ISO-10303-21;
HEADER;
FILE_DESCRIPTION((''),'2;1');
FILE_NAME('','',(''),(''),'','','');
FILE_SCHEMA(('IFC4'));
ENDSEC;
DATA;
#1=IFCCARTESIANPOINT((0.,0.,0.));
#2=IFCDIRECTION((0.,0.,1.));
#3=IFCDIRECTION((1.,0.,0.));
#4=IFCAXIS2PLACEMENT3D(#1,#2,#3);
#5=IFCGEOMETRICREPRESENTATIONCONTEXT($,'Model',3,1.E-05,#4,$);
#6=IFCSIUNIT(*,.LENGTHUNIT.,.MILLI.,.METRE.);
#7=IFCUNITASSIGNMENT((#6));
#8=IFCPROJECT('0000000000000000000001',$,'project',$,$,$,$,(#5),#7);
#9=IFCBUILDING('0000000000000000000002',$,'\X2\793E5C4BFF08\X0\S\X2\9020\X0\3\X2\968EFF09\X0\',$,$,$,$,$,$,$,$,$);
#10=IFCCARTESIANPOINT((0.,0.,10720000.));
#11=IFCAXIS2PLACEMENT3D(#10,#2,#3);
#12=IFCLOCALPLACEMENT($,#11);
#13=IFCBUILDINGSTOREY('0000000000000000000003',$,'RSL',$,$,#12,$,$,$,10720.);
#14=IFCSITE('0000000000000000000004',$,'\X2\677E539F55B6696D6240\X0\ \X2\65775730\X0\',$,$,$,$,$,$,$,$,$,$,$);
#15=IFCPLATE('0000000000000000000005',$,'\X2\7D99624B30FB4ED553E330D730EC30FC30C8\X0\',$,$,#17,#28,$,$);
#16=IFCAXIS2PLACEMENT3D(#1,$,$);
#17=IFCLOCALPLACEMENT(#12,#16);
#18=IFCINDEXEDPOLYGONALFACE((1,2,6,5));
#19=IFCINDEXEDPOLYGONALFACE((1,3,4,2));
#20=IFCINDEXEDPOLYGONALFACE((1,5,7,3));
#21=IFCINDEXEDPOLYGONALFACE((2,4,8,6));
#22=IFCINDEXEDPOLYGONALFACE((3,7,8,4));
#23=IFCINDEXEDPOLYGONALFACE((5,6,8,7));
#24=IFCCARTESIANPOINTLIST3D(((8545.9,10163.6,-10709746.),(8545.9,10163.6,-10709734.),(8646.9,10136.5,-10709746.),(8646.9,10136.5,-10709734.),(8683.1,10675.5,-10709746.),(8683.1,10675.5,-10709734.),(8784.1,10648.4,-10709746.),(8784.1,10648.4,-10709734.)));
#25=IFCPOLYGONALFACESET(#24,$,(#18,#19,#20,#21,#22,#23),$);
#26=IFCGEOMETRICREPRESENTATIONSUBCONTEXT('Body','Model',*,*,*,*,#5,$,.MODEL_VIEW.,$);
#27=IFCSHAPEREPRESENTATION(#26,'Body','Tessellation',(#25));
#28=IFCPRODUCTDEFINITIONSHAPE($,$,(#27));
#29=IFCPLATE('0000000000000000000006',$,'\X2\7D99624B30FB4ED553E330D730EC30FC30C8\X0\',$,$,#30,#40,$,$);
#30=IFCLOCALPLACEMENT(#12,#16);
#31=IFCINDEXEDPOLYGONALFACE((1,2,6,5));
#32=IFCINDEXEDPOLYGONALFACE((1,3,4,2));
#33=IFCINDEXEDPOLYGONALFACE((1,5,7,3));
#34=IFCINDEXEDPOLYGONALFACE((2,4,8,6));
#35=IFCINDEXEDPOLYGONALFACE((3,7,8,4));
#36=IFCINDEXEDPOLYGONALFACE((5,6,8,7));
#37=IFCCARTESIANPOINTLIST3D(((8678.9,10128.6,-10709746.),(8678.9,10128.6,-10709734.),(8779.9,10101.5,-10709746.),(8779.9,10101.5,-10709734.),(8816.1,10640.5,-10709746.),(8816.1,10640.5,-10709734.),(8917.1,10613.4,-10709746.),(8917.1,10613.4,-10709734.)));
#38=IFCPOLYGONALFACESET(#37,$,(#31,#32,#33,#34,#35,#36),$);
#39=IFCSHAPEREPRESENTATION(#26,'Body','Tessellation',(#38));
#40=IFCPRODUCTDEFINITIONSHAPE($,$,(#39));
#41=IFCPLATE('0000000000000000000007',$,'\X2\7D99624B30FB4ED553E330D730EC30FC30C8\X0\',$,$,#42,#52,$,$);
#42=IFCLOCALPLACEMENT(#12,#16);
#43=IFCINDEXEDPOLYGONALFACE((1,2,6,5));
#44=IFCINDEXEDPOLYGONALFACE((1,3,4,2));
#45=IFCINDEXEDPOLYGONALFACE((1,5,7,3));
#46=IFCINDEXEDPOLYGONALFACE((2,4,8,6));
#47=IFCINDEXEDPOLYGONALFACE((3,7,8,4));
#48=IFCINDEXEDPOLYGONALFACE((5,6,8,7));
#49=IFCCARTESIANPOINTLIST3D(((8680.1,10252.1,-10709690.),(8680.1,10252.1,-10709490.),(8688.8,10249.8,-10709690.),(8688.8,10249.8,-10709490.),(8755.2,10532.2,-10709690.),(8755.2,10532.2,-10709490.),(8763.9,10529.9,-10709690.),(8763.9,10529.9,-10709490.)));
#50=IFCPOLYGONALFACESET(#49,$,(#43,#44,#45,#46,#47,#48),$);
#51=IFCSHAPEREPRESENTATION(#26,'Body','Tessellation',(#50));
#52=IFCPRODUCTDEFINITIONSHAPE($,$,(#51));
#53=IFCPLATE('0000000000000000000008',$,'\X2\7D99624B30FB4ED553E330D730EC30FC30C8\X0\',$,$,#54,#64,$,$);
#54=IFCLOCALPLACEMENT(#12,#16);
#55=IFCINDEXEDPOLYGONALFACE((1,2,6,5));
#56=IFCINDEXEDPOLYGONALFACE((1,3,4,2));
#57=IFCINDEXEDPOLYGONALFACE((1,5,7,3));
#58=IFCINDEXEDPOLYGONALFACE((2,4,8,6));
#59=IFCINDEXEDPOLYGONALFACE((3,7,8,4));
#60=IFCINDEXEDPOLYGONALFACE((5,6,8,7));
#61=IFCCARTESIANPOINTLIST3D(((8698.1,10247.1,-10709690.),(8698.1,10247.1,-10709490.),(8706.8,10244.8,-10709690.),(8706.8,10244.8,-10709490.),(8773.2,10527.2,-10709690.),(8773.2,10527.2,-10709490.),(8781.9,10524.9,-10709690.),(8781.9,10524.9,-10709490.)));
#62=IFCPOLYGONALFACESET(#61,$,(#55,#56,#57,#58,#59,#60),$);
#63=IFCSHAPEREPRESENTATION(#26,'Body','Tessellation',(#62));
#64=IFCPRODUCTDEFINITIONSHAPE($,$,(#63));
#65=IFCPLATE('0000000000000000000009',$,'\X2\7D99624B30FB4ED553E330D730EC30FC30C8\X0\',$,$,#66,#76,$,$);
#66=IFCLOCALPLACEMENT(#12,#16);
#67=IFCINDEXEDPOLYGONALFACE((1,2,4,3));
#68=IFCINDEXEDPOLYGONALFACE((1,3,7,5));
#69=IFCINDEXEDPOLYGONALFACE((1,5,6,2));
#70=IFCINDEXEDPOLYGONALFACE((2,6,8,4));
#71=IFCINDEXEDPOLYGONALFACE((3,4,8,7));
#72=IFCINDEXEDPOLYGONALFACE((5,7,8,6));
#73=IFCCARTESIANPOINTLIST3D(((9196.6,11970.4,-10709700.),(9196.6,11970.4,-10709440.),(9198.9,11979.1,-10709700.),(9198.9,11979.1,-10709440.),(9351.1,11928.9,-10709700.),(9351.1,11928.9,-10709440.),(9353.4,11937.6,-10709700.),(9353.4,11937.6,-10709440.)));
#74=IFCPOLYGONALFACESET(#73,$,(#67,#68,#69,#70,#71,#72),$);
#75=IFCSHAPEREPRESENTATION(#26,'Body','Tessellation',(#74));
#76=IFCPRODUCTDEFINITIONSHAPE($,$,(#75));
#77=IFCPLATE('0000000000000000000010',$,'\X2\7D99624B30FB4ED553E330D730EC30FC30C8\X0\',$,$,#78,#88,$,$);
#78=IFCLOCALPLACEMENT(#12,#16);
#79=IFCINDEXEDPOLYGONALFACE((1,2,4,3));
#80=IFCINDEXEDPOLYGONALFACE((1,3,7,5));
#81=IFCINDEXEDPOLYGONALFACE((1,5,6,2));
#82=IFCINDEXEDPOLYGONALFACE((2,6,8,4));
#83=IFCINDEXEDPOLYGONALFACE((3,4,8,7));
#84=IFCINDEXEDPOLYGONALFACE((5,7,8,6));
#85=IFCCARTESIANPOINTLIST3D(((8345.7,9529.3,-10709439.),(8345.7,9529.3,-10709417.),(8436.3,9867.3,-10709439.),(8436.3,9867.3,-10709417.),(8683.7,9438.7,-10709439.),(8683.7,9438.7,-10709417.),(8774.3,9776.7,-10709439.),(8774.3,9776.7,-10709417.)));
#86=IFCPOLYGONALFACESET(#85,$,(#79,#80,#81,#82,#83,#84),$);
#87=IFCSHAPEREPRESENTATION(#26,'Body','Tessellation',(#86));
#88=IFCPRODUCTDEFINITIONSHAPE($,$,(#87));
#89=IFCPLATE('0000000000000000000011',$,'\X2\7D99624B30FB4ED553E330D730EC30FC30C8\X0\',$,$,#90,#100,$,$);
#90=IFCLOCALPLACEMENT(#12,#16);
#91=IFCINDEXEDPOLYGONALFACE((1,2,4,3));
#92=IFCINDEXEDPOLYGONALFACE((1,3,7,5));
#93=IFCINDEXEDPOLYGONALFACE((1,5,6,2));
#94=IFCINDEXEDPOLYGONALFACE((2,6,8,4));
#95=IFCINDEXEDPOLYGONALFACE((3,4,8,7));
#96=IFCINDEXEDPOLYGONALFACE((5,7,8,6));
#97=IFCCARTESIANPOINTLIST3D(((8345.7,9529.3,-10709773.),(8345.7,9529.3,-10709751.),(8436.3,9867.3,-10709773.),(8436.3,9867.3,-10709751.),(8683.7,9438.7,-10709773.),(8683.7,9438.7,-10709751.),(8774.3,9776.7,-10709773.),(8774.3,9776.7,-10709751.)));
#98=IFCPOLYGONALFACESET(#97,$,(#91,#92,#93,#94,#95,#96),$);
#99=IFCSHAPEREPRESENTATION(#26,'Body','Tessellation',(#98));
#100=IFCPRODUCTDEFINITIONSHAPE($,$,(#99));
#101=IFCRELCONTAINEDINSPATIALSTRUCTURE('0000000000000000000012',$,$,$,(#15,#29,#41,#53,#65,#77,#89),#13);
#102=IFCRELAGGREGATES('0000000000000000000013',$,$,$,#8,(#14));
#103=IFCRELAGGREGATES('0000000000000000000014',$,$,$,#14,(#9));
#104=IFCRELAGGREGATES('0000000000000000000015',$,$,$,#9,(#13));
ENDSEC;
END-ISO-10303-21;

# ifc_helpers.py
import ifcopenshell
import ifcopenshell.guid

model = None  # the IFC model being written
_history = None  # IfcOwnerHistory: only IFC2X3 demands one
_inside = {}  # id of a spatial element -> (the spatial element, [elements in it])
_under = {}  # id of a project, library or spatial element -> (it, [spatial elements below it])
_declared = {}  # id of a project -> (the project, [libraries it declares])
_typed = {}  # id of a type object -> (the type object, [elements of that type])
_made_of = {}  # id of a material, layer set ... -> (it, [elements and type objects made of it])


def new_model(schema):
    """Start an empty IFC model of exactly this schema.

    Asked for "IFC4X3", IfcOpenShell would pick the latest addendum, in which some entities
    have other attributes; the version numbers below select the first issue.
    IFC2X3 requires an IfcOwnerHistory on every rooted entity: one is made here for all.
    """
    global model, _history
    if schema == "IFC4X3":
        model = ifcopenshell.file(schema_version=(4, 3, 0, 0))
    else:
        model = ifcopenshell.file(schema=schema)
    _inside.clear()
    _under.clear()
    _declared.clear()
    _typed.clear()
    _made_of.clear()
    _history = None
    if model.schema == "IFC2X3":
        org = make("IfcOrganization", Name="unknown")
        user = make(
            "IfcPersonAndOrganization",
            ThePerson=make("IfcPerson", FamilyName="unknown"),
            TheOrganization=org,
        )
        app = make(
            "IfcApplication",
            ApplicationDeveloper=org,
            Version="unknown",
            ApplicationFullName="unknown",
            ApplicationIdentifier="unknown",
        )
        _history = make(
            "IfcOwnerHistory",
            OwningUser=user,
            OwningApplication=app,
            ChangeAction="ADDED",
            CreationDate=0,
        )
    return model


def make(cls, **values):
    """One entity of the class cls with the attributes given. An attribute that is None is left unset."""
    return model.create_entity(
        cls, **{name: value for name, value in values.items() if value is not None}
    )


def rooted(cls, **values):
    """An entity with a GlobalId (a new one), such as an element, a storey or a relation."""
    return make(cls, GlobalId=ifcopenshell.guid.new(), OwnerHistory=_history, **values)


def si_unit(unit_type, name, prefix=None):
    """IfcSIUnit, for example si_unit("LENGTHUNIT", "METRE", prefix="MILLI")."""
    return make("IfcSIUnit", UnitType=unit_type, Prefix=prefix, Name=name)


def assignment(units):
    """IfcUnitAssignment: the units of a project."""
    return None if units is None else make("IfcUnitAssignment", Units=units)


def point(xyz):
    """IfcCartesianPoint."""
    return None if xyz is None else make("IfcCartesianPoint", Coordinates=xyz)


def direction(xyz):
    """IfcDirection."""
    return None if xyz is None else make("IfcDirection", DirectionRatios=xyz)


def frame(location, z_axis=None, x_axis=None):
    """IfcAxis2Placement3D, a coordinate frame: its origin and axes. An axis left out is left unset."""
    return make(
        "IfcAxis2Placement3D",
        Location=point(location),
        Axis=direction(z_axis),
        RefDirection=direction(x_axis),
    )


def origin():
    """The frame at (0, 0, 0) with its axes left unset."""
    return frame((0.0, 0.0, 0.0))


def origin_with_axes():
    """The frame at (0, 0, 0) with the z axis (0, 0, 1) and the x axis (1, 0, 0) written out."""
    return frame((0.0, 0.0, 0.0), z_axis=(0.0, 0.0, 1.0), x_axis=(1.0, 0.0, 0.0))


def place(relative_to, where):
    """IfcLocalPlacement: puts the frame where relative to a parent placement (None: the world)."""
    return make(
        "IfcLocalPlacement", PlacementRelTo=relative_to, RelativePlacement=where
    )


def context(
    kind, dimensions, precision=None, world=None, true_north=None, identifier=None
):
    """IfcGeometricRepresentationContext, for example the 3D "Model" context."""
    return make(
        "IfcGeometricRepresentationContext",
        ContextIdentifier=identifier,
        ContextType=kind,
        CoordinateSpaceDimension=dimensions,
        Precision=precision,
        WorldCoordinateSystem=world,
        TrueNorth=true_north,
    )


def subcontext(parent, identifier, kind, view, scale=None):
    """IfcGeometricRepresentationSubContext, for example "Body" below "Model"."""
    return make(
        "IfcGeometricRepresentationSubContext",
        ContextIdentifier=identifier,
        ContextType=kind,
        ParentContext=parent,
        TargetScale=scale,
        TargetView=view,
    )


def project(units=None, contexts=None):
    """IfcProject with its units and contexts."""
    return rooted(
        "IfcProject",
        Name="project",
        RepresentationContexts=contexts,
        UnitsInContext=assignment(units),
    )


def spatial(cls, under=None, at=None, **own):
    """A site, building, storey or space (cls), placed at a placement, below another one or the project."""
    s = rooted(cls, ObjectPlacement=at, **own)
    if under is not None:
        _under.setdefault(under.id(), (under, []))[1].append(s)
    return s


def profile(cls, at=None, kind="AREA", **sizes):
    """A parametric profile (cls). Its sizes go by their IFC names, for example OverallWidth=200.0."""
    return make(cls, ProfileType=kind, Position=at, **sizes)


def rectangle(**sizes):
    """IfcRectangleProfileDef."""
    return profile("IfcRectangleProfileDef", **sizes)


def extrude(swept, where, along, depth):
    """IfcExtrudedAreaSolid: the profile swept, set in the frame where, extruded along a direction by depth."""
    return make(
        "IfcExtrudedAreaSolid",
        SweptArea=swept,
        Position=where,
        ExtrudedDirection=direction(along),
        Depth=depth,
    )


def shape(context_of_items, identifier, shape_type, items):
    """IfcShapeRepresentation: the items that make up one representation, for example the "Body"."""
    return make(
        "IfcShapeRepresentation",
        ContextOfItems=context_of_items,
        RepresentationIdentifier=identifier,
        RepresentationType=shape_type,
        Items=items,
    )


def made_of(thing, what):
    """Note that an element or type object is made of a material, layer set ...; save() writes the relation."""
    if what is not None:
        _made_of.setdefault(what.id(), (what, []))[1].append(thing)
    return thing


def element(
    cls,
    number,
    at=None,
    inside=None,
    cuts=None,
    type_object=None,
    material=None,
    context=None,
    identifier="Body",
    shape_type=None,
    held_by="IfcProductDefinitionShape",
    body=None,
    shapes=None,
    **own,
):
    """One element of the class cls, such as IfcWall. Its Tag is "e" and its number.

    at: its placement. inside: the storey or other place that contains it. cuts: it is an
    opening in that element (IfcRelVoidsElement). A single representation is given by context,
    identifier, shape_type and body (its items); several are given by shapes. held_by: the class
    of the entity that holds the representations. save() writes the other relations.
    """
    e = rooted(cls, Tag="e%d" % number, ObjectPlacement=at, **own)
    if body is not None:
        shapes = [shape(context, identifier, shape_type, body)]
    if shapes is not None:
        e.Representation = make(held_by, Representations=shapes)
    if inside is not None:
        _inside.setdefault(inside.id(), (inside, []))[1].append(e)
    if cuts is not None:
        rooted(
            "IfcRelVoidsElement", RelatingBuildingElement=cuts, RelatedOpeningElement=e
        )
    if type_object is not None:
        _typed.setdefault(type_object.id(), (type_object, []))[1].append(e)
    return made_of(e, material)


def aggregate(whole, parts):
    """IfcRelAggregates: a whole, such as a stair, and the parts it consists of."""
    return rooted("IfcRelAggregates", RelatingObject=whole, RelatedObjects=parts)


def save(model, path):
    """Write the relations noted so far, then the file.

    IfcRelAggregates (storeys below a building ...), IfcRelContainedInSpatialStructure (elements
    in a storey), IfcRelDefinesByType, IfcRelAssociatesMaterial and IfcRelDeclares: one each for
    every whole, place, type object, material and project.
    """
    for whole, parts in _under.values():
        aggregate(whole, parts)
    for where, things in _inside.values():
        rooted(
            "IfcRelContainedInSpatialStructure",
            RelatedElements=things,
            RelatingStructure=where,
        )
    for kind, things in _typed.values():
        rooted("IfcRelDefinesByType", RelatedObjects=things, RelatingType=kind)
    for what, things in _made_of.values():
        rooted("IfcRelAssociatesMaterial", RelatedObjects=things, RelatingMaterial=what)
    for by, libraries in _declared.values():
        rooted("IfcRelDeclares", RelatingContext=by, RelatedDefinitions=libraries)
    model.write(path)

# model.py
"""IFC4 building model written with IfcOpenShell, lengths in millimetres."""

from ifc_helpers import new_model, si_unit, frame, origin, origin_with_axes, place, context, subcontext, project, spatial, rectangle, extrude, element, save


model = new_model("IFC4")

# Units and contexts
model_context = context("Model", 3, precision=1e-05, world=origin_with_axes())
body_context = subcontext(model_context, "Body", "Model", "MODEL_VIEW")
ifc_project = project(units=[si_unit("LENGTHUNIT", "METRE", prefix="MILLI")], contexts=[model_context])

# Site, building, storey
site = spatial("IfcSite", under=ifc_project, Name="松原営業所 敷地")
building = spatial("IfcBuilding", under=site, Name="社屋（S造3階）")
storey_placement = place(None, frame((0.0, 0.0, 10720000.0), z_axis=(0.0, 0.0, 1.0), x_axis=(1.0, 0.0, 0.0)))
storey = spatial("IfcBuildingStorey", under=building, at=storey_placement, Name="RSL", Elevation=10720.0)

# Plates
for number, where, z_axis, x_axis, name in (
    (1, (8596.4, 10150.0, -10709740.0), (0.258819, 0.965926, 0.0), (-0.965926, 0.258819, 0.0), "継手・仕口プレート"),
    (2, (8729.4, 10115.0, -10709740.0), (0.258819, 0.965926, 0.0), (-0.965926, 0.258819, 0.0), "継手・仕口プレート"),
):
    element("IfcPlate", number, at=place(storey_placement, frame(where, z_axis=z_axis, x_axis=x_axis)), inside=storey, Name=name, context=body_context, shape_type="SweptSolid", body=[
        extrude(rectangle(XDim=104.5, YDim=12.0), origin(), (0.0, 0.0, 1.0), 530.0),
    ])
for number, where, z_axis, x_axis, name in (
    (3, (8684.5, 10250.9, -10709590.0), (0.258819, 0.965926, 0.0), (-0.965926, 0.258819, 0.0), "継手・仕口プレート"),
    (4, (8702.5, 10245.9, -10709590.0), (0.258819, 0.965926, 0.0), (-0.965926, 0.258819, 0.0), "継手・仕口プレート"),
):
    element("IfcPlate", number, at=place(storey_placement, frame(where, z_axis=z_axis, x_axis=x_axis)), inside=storey, Name=name, context=body_context, shape_type="SweptSolid", body=[
        extrude(rectangle(XDim=9.0, YDim=200.0), origin(), (0.0, 0.0, 1.0), 290.0),
    ])
plate_1_placement = place(storey_placement, frame((9197.7, 11974.7, -10709570.0), z_axis=(0.965926, -0.258819, 0.0), x_axis=(0.258819, 0.965926, 0.0)))
element("IfcPlate", 5, at=plate_1_placement, inside=storey, Name="継手・仕口プレート", context=body_context, shape_type="SweptSolid", body=[
    extrude(rectangle(XDim=9.0, YDim=260.0), origin(), (0.0, 0.0, 1.0), 160.0),
])
for number, where, z_axis, x_axis, name in (
    (6, (8391.0, 9698.3, -10709428.0), (0.965926, -0.258819, 0.0), (0.258819, 0.965926, 0.0), "継手・仕口プレート"),
    (7, (8391.0, 9698.3, -10709762.0), (0.965926, -0.258819, 0.0), (0.258819, 0.965926, 0.0), "継手・仕口プレート"),
):
    element("IfcPlate", number, at=place(storey_placement, frame(where, z_axis=z_axis, x_axis=x_axis)), inside=storey, Name=name, context=body_context, shape_type="SweptSolid", body=[
        extrude(rectangle(XDim=350.0, YDim=22.0), origin(), (0.0, 0.0, 1.0), 350.0),
    ])

save(model, "model.ifc")
